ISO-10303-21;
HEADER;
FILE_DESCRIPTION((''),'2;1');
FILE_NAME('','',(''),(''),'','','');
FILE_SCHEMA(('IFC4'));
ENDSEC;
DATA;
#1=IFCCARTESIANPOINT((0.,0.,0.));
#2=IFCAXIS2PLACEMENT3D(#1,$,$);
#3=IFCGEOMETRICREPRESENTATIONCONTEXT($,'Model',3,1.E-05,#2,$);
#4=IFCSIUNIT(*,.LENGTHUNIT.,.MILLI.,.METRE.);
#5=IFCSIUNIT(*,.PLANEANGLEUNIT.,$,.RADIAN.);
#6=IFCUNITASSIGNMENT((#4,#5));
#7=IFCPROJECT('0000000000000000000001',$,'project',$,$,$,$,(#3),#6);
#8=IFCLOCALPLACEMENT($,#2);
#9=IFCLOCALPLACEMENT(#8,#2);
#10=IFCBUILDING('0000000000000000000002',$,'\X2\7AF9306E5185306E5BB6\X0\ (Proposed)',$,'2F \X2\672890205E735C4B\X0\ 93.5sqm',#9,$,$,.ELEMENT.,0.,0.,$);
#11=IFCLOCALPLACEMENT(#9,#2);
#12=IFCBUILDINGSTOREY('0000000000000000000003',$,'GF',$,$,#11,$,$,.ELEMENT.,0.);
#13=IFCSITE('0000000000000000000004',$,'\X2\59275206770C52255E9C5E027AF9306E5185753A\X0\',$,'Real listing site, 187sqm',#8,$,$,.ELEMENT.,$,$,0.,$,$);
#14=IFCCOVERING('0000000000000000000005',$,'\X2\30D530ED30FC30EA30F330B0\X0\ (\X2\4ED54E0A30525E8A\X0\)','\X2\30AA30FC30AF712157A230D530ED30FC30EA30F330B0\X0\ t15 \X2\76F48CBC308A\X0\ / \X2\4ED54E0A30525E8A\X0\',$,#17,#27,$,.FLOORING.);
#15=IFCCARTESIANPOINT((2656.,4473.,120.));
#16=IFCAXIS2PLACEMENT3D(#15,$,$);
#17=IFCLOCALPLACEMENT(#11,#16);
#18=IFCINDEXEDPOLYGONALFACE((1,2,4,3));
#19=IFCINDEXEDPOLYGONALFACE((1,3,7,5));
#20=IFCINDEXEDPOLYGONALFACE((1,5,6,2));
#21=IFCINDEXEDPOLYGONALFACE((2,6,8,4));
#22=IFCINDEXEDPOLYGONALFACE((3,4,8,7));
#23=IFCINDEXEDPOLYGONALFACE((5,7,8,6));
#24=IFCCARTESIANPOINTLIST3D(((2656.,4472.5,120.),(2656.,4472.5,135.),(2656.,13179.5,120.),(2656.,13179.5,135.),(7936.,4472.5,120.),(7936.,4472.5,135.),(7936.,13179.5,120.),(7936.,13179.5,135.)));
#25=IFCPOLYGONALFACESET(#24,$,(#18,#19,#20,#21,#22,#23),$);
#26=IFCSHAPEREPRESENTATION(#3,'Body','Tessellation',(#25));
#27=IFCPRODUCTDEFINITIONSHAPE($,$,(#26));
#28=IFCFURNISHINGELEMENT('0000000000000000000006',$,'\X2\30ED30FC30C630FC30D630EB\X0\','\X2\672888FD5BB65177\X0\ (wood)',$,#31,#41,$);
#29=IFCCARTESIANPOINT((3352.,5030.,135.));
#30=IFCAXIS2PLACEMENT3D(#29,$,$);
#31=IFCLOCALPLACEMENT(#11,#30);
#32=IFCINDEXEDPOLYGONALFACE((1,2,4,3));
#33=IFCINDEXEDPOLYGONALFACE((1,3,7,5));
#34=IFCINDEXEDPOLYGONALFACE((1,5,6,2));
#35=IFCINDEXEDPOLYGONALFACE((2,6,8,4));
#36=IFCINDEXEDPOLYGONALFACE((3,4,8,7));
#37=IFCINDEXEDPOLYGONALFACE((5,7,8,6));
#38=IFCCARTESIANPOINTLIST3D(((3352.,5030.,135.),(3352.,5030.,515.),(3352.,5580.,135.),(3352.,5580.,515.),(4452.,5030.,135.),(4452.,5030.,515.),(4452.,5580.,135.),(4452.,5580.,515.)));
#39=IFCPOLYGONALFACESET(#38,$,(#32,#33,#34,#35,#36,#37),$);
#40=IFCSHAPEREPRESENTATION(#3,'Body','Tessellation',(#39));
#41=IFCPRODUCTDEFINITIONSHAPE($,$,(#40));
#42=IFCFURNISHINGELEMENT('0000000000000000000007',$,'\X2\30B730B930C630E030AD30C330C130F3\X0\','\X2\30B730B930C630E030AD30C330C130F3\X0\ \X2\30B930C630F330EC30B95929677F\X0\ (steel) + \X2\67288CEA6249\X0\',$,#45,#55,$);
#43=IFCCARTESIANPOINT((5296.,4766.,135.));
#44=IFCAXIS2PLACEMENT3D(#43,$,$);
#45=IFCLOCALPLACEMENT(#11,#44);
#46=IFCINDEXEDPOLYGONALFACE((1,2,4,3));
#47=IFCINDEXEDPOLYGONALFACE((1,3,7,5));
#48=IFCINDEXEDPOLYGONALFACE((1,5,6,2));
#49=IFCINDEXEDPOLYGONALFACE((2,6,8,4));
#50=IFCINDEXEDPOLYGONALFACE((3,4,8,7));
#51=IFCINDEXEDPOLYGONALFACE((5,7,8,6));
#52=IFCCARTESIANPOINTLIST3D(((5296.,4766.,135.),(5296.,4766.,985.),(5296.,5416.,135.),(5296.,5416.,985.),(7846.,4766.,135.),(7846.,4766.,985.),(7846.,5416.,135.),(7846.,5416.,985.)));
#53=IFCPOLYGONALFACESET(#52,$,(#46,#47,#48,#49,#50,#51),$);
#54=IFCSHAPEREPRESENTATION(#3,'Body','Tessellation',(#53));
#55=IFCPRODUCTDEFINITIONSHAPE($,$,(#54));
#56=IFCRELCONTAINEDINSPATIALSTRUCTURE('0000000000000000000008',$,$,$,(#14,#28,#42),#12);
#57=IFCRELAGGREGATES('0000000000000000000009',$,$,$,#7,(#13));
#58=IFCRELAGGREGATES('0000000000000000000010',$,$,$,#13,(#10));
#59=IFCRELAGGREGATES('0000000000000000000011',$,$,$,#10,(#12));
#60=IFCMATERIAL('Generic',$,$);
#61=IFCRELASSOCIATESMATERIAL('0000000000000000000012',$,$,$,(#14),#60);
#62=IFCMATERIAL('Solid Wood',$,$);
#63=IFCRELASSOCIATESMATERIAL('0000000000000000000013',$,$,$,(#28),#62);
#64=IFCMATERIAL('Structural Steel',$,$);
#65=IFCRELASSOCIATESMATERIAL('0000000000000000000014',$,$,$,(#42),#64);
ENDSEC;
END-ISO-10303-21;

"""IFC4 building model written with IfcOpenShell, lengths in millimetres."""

from ifc_helpers import new_model, si_unit, frame, frame_2d, origin, place, context, project, spatial, rectangle, extrude, material, element, save


model = new_model("IFC4")

# Units and contexts
model_context = context("Model", 3, precision=1e-05, world=origin())
ifc_project = project(units=[si_unit("LENGTHUNIT", "METRE", prefix="MILLI"), si_unit("PLANEANGLEUNIT", "RADIAN")], contexts=[model_context])

# Site, building, storey
site_placement = place(None, origin())
site = spatial("IfcSite", under=ifc_project, at=site_placement, Name="大分県別府市竹の内町", ObjectType="Real listing site, 187sqm", CompositionType="ELEMENT", RefElevation=0.0)
building_placement = place(site_placement, origin())
building = spatial("IfcBuilding", under=site, at=building_placement, Name="竹の内の家 (Proposed)", ObjectType="2F 木造平屋 93.5sqm", CompositionType="ELEMENT", ElevationOfRefHeight=0.0, ElevationOfTerrain=0.0)
storey_placement = place(building_placement, origin())
storey = spatial("IfcBuildingStorey", under=building, at=storey_placement, Name="GF", CompositionType="ELEMENT", Elevation=0.0)

# Shared definitions
ifc_material_1 = material(Name="Solid Wood")

# Covering
ifc_material_2 = material(Name="Generic")
covering_placement = place(storey_placement, frame((2656.0, 4473.0, 120.0)))
element("IfcCovering", 1, at=covering_placement, inside=storey, material=ifc_material_2, Name="フローリング (仕上げ床)", Description="オーク無垢フローリング t15 直貼り / 仕上げ床", PredefinedType="FLOORING", context=model_context, shape_type="SweptSolid", body=[
    extrude(rectangle(XDim=5280.0, YDim=8707.0, at=frame_2d((2640.0, 4353.0))), frame((2656.0, 4473.0, 120.0)), (0.0, 0.0, 1.0), 15.0),
])

# Furnishing elements
furnishing_1_placement = place(storey_placement, frame((3352.0, 5030.0, 135.0)))
element("IfcFurnishingElement", 2, at=furnishing_1_placement, inside=storey, material=ifc_material_1, Name="ローテーブル", Description="木製家具 (wood)", context=model_context, shape_type="SweptSolid", body=[
    extrude(rectangle(XDim=1100.0, YDim=550.0, at=frame_2d((550.0, 275.0))), frame((3352.0, 5030.0, 135.0)), (0.0, 0.0, 1.0), 380.0),
])
ifc_material_3 = material(Name="Structural Steel")
furnishing_2_placement = place(storey_placement, frame((5296.0, 4766.0, 135.0)))
element("IfcFurnishingElement", 3, at=furnishing_2_placement, inside=storey, material=ifc_material_3, Name="システムキッチン", Description="システムキッチン ステンレス天板 (steel) + 木質扉", context=model_context, shape_type="SweptSolid", body=[
    extrude(rectangle(XDim=2550.0, YDim=650.0, at=frame_2d((1275.0, 325.0))), frame((5296.0, 4766.0, 135.0)), (0.0, 0.0, 1.0), 850.0),
])

save(model, "model.ifc")
